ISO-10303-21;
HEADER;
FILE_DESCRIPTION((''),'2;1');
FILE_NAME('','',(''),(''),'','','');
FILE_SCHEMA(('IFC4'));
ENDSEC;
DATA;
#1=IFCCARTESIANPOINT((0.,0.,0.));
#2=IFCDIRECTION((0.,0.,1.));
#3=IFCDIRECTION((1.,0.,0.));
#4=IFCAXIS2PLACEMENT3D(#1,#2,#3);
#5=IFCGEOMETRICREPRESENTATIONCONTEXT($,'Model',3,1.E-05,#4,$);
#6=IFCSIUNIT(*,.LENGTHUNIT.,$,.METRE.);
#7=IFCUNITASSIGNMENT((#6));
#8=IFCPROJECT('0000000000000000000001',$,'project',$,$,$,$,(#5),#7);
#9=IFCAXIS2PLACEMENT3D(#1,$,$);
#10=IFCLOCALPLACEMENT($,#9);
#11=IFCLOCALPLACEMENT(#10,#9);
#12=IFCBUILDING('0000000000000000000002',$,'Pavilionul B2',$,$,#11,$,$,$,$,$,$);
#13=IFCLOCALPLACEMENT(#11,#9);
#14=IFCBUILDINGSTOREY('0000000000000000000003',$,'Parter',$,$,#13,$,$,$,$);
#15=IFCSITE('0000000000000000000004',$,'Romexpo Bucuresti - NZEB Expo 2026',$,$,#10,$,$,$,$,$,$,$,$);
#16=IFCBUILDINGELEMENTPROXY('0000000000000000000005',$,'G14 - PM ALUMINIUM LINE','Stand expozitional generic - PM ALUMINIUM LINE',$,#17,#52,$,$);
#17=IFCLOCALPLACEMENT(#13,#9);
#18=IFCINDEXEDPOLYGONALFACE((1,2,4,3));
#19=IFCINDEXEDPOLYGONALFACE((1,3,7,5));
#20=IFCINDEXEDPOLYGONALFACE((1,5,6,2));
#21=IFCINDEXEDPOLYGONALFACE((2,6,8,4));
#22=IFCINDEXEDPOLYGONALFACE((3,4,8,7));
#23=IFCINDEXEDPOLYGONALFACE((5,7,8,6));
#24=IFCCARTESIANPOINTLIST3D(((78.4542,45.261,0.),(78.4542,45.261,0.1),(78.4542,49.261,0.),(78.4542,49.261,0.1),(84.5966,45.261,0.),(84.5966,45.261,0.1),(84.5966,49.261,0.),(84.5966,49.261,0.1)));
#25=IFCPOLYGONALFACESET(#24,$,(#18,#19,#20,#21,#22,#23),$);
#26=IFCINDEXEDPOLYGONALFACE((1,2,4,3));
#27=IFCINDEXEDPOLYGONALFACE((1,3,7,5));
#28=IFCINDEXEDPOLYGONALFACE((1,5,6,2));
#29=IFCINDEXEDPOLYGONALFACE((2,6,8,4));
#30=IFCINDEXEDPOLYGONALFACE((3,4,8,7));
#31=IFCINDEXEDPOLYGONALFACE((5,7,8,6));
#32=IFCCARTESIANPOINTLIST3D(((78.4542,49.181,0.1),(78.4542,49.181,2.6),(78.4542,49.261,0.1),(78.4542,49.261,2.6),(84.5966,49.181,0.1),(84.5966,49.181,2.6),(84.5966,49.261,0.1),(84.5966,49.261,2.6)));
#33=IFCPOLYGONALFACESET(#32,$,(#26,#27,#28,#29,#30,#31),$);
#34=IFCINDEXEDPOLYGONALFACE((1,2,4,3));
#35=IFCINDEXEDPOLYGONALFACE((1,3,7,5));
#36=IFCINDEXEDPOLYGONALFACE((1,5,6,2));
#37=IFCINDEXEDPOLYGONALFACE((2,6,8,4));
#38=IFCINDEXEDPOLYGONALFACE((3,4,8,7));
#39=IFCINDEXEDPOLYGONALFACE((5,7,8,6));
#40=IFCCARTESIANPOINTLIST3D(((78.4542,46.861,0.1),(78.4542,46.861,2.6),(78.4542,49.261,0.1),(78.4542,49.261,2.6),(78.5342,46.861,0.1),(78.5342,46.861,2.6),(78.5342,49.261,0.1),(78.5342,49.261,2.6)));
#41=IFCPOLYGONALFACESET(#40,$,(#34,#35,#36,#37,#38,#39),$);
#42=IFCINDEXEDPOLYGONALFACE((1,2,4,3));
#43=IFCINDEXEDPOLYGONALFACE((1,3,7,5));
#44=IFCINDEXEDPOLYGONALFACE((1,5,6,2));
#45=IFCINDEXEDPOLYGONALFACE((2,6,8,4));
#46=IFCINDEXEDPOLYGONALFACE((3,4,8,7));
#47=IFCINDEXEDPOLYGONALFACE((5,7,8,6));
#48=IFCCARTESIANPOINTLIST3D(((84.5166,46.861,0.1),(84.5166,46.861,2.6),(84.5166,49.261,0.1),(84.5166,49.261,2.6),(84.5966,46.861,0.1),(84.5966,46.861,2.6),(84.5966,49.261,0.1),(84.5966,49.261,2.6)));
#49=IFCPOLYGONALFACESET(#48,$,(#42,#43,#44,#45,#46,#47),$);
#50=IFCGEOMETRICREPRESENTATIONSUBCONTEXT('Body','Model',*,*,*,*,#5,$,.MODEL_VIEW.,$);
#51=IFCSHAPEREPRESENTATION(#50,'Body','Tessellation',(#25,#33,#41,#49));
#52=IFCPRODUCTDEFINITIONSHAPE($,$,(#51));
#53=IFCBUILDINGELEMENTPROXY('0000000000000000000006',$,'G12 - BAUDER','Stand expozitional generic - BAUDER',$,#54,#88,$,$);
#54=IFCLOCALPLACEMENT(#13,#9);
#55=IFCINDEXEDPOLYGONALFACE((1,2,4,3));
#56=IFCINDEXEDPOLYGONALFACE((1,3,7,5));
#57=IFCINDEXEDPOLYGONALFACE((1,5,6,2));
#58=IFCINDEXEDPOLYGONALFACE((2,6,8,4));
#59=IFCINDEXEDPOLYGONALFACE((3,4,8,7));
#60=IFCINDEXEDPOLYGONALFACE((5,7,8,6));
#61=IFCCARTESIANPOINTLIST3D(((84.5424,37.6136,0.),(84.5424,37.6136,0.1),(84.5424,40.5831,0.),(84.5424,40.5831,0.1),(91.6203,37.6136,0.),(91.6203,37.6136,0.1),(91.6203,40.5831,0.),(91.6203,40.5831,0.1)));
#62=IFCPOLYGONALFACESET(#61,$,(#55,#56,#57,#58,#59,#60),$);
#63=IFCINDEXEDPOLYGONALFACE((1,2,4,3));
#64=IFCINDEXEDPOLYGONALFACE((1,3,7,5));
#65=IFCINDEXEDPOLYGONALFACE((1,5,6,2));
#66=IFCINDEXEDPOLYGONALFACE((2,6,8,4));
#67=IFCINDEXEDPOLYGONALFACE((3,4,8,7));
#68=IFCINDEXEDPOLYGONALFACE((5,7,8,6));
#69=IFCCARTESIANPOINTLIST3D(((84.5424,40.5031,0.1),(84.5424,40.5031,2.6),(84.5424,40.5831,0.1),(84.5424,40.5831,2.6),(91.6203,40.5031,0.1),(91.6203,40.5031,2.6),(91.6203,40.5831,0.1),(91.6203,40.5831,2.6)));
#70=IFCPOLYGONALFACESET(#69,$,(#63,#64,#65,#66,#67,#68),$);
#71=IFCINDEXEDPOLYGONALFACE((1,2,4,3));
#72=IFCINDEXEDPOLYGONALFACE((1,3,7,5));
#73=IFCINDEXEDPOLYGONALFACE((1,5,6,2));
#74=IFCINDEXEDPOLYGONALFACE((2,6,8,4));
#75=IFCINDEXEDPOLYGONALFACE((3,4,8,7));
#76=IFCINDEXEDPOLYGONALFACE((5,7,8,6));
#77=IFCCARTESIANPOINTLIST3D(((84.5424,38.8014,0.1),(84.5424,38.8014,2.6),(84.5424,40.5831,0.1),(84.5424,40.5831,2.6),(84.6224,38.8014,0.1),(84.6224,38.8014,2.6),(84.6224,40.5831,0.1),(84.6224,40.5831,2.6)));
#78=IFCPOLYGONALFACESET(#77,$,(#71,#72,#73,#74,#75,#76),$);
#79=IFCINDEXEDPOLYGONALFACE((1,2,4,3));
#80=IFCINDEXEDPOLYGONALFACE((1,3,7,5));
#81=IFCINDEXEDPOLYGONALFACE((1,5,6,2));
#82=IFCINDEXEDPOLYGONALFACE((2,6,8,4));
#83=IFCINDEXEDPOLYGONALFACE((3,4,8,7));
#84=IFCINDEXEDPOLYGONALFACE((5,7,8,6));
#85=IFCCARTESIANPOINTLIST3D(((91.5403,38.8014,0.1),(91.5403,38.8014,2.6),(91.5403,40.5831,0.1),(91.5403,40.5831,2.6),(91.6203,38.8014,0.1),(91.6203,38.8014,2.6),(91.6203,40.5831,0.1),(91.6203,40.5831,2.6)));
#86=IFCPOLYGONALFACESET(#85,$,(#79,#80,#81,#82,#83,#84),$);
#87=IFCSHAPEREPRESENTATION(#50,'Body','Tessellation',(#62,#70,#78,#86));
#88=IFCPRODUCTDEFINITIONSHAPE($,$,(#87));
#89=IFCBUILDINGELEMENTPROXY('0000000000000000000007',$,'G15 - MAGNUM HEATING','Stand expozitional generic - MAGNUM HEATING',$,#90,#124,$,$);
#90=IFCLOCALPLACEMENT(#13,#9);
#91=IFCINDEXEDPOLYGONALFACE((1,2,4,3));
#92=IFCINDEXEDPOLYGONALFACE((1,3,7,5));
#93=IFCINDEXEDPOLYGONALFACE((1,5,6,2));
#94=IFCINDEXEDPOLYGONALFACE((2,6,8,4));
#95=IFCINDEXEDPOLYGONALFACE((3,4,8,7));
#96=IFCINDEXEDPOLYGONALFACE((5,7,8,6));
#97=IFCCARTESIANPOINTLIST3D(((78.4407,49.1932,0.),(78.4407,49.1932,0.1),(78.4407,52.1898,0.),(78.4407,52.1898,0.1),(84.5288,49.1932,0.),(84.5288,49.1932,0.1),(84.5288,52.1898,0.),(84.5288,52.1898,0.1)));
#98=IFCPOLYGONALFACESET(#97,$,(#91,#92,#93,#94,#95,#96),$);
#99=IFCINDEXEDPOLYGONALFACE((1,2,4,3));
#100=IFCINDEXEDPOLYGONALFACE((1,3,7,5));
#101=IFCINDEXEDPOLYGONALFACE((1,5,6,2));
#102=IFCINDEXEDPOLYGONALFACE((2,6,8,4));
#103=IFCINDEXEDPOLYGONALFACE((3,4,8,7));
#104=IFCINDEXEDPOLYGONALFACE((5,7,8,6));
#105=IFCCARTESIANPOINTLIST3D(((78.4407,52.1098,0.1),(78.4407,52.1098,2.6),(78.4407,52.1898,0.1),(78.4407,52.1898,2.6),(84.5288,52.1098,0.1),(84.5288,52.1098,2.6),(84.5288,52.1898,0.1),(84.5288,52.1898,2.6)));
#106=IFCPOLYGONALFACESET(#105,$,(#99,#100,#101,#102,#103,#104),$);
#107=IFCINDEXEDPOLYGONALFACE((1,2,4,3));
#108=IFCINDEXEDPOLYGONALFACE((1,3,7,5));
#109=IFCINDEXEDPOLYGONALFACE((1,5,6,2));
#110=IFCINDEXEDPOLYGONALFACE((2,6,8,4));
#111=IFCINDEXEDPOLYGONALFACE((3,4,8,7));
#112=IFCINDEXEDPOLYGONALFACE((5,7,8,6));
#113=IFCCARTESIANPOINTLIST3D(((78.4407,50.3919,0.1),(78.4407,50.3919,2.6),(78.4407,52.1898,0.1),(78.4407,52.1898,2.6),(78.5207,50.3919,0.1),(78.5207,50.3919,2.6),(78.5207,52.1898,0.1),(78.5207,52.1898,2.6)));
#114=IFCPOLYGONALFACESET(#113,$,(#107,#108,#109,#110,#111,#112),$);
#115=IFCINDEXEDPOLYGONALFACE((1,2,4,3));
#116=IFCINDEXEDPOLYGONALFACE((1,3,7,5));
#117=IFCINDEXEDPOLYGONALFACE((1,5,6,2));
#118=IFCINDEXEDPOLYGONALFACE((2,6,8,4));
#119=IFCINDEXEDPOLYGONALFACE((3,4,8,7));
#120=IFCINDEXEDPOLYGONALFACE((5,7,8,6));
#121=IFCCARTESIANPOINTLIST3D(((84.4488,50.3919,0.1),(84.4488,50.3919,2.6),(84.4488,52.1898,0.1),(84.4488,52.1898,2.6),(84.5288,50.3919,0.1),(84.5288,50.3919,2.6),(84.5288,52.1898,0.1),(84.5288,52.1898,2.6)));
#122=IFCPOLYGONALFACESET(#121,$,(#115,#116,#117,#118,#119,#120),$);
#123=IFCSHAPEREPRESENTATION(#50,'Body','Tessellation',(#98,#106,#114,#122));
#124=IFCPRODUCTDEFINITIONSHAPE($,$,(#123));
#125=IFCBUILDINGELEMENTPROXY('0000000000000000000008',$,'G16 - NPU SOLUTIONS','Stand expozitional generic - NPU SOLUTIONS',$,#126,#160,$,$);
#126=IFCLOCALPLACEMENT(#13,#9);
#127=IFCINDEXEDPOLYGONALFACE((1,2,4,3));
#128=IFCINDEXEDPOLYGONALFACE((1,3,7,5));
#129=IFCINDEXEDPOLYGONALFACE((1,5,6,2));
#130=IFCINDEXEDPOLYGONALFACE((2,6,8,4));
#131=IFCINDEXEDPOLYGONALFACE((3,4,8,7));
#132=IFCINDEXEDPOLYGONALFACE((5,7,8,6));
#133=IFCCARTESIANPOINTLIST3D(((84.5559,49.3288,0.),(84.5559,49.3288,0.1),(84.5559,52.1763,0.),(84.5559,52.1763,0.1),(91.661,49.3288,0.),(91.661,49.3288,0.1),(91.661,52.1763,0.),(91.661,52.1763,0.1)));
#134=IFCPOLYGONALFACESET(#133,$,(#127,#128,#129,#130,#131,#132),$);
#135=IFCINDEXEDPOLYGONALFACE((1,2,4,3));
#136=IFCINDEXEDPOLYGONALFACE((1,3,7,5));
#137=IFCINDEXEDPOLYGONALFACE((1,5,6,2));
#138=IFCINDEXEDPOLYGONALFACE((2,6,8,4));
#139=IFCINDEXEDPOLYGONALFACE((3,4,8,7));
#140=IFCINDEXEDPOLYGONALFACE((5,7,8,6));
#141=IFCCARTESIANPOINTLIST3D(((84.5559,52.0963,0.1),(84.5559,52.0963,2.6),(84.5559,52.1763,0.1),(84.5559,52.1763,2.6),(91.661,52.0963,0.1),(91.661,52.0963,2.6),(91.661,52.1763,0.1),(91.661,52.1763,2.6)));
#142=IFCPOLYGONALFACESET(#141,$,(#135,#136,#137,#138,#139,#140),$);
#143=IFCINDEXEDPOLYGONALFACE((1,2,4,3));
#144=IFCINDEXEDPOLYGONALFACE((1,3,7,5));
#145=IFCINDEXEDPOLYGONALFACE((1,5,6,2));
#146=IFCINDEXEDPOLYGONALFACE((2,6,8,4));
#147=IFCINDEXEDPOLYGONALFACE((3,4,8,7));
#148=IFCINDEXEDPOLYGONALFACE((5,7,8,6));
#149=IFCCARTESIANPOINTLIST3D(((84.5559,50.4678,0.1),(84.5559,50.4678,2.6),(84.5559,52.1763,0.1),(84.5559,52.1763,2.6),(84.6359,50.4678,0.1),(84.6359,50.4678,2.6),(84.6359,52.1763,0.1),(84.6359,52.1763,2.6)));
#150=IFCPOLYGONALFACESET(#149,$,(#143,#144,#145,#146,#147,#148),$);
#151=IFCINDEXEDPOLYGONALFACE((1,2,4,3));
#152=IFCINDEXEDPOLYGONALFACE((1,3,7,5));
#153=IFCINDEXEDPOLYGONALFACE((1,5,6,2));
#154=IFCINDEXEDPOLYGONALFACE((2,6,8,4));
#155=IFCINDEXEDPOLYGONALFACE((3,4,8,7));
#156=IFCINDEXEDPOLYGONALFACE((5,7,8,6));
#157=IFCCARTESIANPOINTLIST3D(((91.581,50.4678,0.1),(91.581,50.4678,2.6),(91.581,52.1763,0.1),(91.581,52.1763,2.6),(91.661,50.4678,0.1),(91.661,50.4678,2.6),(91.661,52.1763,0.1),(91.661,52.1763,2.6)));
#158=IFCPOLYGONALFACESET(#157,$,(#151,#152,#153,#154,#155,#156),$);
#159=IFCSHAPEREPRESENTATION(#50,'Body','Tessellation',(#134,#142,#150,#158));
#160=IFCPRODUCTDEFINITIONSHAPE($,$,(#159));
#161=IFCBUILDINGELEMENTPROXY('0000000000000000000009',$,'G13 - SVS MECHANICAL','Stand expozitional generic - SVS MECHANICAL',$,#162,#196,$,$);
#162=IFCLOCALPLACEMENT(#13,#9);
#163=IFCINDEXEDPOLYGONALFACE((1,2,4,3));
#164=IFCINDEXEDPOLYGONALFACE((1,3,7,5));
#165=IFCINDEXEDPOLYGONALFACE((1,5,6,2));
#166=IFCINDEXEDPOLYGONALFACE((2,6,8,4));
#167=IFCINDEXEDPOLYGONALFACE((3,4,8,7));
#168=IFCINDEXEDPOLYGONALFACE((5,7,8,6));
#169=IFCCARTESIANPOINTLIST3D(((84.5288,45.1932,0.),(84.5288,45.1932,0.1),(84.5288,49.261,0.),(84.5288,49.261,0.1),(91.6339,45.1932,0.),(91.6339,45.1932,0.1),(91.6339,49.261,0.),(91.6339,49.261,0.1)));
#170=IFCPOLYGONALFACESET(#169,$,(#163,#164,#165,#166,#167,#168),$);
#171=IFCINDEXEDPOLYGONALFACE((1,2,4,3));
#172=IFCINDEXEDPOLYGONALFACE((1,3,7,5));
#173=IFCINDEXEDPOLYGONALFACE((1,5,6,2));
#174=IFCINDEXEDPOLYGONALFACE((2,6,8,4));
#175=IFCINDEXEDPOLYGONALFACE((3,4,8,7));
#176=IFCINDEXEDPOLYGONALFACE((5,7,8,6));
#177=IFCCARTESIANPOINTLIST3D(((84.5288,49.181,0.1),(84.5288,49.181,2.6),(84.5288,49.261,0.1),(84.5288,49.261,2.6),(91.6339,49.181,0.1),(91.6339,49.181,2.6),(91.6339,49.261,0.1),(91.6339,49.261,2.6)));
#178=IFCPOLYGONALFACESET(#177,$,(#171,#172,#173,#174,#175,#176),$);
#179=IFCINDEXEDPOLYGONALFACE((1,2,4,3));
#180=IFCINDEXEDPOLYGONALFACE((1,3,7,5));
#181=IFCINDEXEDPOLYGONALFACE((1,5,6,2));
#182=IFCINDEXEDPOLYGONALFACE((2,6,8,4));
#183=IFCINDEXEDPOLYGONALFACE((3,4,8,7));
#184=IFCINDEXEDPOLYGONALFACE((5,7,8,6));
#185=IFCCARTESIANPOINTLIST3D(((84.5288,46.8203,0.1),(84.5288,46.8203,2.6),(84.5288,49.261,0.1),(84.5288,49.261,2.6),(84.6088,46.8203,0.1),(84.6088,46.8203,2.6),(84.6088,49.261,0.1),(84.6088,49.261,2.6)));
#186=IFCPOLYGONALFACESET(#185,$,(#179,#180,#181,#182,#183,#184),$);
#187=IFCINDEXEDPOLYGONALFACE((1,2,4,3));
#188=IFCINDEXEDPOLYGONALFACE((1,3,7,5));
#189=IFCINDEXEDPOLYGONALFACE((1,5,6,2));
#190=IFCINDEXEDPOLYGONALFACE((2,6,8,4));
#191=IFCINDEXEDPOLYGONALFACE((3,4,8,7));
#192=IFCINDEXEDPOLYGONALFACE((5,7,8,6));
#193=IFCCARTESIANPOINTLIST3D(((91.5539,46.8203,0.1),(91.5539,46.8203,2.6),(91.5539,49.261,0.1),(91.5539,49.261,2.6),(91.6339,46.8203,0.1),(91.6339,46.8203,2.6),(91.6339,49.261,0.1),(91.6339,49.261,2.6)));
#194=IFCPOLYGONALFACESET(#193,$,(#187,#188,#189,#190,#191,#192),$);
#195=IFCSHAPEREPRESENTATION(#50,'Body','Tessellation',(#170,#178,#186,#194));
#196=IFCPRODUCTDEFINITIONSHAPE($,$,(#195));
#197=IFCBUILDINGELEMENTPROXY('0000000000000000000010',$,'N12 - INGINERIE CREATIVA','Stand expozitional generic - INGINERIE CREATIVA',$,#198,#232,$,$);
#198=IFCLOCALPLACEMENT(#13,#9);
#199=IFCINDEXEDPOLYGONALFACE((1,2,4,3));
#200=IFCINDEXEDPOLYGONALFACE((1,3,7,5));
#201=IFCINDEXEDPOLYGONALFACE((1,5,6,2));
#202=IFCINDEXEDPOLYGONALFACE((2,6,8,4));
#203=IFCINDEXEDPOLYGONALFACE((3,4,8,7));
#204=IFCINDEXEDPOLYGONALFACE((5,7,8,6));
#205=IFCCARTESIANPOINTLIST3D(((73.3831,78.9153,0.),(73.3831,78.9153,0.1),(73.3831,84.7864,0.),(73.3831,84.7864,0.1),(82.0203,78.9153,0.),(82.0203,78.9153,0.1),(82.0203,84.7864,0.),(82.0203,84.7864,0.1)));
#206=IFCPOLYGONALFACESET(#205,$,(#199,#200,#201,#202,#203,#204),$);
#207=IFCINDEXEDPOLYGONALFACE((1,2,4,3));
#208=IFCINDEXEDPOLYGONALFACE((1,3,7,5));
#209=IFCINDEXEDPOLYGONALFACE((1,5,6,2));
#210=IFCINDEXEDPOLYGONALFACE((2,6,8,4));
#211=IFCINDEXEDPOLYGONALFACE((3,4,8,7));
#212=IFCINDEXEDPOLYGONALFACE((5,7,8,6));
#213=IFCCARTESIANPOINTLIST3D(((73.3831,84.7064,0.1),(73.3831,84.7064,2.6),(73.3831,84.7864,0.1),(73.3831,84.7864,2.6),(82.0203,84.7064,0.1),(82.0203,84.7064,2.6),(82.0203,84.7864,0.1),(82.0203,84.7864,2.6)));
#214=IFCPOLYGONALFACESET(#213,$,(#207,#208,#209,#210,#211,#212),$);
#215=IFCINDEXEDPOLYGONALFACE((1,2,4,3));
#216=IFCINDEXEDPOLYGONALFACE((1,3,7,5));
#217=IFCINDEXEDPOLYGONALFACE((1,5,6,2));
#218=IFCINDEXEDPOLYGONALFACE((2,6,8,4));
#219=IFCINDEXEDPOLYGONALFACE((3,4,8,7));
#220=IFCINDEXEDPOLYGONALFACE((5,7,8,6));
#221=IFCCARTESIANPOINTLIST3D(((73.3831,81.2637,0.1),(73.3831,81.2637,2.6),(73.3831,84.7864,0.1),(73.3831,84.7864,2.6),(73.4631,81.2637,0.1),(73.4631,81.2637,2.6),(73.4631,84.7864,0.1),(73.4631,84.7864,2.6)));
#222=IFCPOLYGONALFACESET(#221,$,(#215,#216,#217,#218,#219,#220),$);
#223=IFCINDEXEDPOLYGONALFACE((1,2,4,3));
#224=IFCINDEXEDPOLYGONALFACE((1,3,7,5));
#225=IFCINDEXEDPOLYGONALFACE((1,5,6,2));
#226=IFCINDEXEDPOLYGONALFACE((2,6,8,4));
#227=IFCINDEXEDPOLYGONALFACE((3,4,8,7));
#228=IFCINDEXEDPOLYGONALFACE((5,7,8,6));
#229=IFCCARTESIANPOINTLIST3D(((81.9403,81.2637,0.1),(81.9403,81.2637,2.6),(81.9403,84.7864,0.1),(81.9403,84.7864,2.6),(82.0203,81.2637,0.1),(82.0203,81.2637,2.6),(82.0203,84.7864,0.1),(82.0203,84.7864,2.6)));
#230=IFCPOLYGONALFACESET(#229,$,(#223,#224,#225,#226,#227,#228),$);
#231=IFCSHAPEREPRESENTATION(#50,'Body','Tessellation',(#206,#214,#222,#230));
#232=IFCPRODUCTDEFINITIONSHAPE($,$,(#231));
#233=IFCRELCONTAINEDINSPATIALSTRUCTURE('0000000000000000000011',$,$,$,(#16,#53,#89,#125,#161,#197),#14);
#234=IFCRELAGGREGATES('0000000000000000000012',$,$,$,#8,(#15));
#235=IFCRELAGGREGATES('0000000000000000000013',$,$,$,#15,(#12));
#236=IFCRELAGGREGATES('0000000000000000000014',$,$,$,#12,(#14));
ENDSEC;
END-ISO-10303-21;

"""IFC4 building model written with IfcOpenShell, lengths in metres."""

from ifc_helpers import new_model, si_unit, frame, frame_2d, origin, origin_with_axes, place, context, subcontext, project, spatial, rectangle, extrude, element, save


model = new_model("IFC4")

# Units and contexts
model_context = context("Model", 3, precision=1e-05, world=origin_with_axes())
body_context = subcontext(model_context, "Body", "Model", "MODEL_VIEW")
ifc_project = project(units=[si_unit("LENGTHUNIT", "METRE")], contexts=[model_context])

# Site, building, storey
site_placement = place(None, origin())
site = spatial("IfcSite", under=ifc_project, at=site_placement, Name="Romexpo Bucuresti - NZEB Expo 2026")
building_placement = place(site_placement, origin())
building = spatial("IfcBuilding", under=site, at=building_placement, Name="Pavilionul B2")
storey_placement = place(building_placement, origin())
storey = spatial("IfcBuildingStorey", under=building, at=storey_placement, Name="Parter")

# Building element proxies
proxy_1_placement = place(storey_placement, frame((78.4542, 45.261, 0.0), z_axis=(0.0, 0.0, 1.0), x_axis=(1.0, 0.0, 0.0)))
element("IfcBuildingElementProxy", 1, at=proxy_1_placement, inside=storey, Name="G14 - PM ALUMINIUM LINE", Description="Stand expozitional generic - PM ALUMINIUM LINE", context=body_context, shape_type="SweptSolid", body=[
    extrude(rectangle(XDim=6.1424, YDim=4.0, at=frame_2d((3.0712, 2.0))), origin(), (0.0, 0.0, 1.0), 0.1),
    extrude(rectangle(XDim=6.1424, YDim=0.08, at=frame_2d((3.0712, 3.96))), frame((0.0, 0.0, 0.1)), (0.0, 0.0, 1.0), 2.5),
    extrude(rectangle(XDim=0.08, YDim=2.4, at=frame_2d((0.04, 2.8))), frame((0.0, 0.0, 0.1)), (0.0, 0.0, 1.0), 2.5),
    extrude(rectangle(XDim=0.08, YDim=2.4, at=frame_2d((6.1024, 2.8))), frame((0.0, 0.0, 0.1)), (0.0, 0.0, 1.0), 2.5),
])
proxy_2_placement = place(storey_placement, frame((84.5424, 37.6136, 0.0), z_axis=(0.0, 0.0, 1.0), x_axis=(1.0, 0.0, 0.0)))
element("IfcBuildingElementProxy", 2, at=proxy_2_placement, inside=storey, Name="G12 - BAUDER", Description="Stand expozitional generic - BAUDER", context=body_context, shape_type="SweptSolid", body=[
    extrude(rectangle(XDim=7.078, YDim=2.9695, at=frame_2d((3.539, 1.4847))), origin(), (0.0, 0.0, 1.0), 0.1),
    extrude(rectangle(XDim=7.078, YDim=0.08, at=frame_2d((3.539, 2.9295))), frame((0.0, 0.0, 0.1)), (0.0, 0.0, 1.0), 2.5),
    extrude(rectangle(XDim=0.08, YDim=1.7817, at=frame_2d((0.04, 2.0786))), frame((0.0, 0.0, 0.1)), (0.0, 0.0, 1.0), 2.5),
    extrude(rectangle(XDim=0.08, YDim=1.7817, at=frame_2d((7.038, 2.0786))), frame((0.0, 0.0, 0.1)), (0.0, 0.0, 1.0), 2.5),
])
proxy_3_placement = place(storey_placement, frame((78.4407, 49.1932, 0.0), z_axis=(0.0, 0.0, 1.0), x_axis=(1.0, 0.0, 0.0)))
element("IfcBuildingElementProxy", 3, at=proxy_3_placement, inside=storey, Name="G15 - MAGNUM HEATING", Description="Stand expozitional generic - MAGNUM HEATING", context=body_context, shape_type="SweptSolid", body=[
    extrude(rectangle(XDim=6.0881, YDim=2.9966, at=frame_2d((3.0441, 1.4983))), origin(), (0.0, 0.0, 1.0), 0.1),
    extrude(rectangle(XDim=6.0881, YDim=0.08, at=frame_2d((3.0441, 2.9566))), frame((0.0, 0.0, 0.1)), (0.0, 0.0, 1.0), 2.5),
    extrude(rectangle(XDim=0.08, YDim=1.798, at=frame_2d((0.04, 2.0976))), frame((0.0, 0.0, 0.1)), (0.0, 0.0, 1.0), 2.5),
    extrude(rectangle(XDim=0.08, YDim=1.798, at=frame_2d((6.0481, 2.0976))), frame((0.0, 0.0, 0.1)), (0.0, 0.0, 1.0), 2.5),
])
proxy_4_placement = place(storey_placement, frame((84.5559, 49.3288, 0.0), z_axis=(0.0, 0.0, 1.0), x_axis=(1.0, 0.0, 0.0)))
element("IfcBuildingElementProxy", 4, at=proxy_4_placement, inside=storey, Name="G16 - NPU SOLUTIONS", Description="Stand expozitional generic - NPU SOLUTIONS", context=body_context, shape_type="SweptSolid", body=[
    extrude(rectangle(XDim=7.1051, YDim=2.8475, at=frame_2d((3.5525, 1.4237))), origin(), (0.0, 0.0, 1.0), 0.1),
    extrude(rectangle(XDim=7.1051, YDim=0.08, at=frame_2d((3.5525, 2.8075))), frame((0.0, 0.0, 0.1)), (0.0, 0.0, 1.0), 2.5),
    extrude(rectangle(XDim=0.08, YDim=1.7085, at=frame_2d((0.04, 1.9932))), frame((0.0, 0.0, 0.1)), (0.0, 0.0, 1.0), 2.5),
    extrude(rectangle(XDim=0.08, YDim=1.7085, at=frame_2d((7.0651, 1.9932))), frame((0.0, 0.0, 0.1)), (0.0, 0.0, 1.0), 2.5),
])
proxy_5_placement = place(storey_placement, frame((84.5288, 45.1932, 0.0), z_axis=(0.0, 0.0, 1.0), x_axis=(1.0, 0.0, 0.0)))
element("IfcBuildingElementProxy", 5, at=proxy_5_placement, inside=storey, Name="G13 - SVS MECHANICAL", Description="Stand expozitional generic - SVS MECHANICAL", context=body_context, shape_type="SweptSolid", body=[
    extrude(rectangle(XDim=7.1051, YDim=4.0678, at=frame_2d((3.5525, 2.0339))), origin(), (0.0, 0.0, 1.0), 0.1),
    extrude(rectangle(XDim=7.1051, YDim=0.08, at=frame_2d((3.5525, 4.0278))), frame((0.0, 0.0, 0.1)), (0.0, 0.0, 1.0), 2.5),
    extrude(rectangle(XDim=0.08, YDim=2.4407, at=frame_2d((0.04, 2.8475))), frame((0.0, 0.0, 0.1)), (0.0, 0.0, 1.0), 2.5),
    extrude(rectangle(XDim=0.08, YDim=2.4407, at=frame_2d((7.0651, 2.8475))), frame((0.0, 0.0, 0.1)), (0.0, 0.0, 1.0), 2.5),
])
proxy_6_placement = place(storey_placement, frame((73.3831, 78.9153, 0.0), z_axis=(0.0, 0.0, 1.0), x_axis=(1.0, 0.0, 0.0)))
element("IfcBuildingElementProxy", 6, at=proxy_6_placement, inside=storey, Name="N12 - INGINERIE CREATIVA", Description="Stand expozitional generic - INGINERIE CREATIVA", context=body_context, shape_type="SweptSolid", body=[
    extrude(rectangle(XDim=8.6373, YDim=5.8712, at=frame_2d((4.3186, 2.9356))), origin(), (0.0, 0.0, 1.0), 0.1),
    extrude(rectangle(XDim=8.6373, YDim=0.08, at=frame_2d((4.3186, 5.8312))), frame((0.0, 0.0, 0.1)), (0.0, 0.0, 1.0), 2.5),
    extrude(rectangle(XDim=0.08, YDim=3.5227, at=frame_2d((0.04, 4.1098))), frame((0.0, 0.0, 0.1)), (0.0, 0.0, 1.0), 2.5),
    extrude(rectangle(XDim=0.08, YDim=3.5227, at=frame_2d((8.5973, 4.1098))), frame((0.0, 0.0, 0.1)), (0.0, 0.0, 1.0), 2.5),
])

save(model, "model.ifc")
